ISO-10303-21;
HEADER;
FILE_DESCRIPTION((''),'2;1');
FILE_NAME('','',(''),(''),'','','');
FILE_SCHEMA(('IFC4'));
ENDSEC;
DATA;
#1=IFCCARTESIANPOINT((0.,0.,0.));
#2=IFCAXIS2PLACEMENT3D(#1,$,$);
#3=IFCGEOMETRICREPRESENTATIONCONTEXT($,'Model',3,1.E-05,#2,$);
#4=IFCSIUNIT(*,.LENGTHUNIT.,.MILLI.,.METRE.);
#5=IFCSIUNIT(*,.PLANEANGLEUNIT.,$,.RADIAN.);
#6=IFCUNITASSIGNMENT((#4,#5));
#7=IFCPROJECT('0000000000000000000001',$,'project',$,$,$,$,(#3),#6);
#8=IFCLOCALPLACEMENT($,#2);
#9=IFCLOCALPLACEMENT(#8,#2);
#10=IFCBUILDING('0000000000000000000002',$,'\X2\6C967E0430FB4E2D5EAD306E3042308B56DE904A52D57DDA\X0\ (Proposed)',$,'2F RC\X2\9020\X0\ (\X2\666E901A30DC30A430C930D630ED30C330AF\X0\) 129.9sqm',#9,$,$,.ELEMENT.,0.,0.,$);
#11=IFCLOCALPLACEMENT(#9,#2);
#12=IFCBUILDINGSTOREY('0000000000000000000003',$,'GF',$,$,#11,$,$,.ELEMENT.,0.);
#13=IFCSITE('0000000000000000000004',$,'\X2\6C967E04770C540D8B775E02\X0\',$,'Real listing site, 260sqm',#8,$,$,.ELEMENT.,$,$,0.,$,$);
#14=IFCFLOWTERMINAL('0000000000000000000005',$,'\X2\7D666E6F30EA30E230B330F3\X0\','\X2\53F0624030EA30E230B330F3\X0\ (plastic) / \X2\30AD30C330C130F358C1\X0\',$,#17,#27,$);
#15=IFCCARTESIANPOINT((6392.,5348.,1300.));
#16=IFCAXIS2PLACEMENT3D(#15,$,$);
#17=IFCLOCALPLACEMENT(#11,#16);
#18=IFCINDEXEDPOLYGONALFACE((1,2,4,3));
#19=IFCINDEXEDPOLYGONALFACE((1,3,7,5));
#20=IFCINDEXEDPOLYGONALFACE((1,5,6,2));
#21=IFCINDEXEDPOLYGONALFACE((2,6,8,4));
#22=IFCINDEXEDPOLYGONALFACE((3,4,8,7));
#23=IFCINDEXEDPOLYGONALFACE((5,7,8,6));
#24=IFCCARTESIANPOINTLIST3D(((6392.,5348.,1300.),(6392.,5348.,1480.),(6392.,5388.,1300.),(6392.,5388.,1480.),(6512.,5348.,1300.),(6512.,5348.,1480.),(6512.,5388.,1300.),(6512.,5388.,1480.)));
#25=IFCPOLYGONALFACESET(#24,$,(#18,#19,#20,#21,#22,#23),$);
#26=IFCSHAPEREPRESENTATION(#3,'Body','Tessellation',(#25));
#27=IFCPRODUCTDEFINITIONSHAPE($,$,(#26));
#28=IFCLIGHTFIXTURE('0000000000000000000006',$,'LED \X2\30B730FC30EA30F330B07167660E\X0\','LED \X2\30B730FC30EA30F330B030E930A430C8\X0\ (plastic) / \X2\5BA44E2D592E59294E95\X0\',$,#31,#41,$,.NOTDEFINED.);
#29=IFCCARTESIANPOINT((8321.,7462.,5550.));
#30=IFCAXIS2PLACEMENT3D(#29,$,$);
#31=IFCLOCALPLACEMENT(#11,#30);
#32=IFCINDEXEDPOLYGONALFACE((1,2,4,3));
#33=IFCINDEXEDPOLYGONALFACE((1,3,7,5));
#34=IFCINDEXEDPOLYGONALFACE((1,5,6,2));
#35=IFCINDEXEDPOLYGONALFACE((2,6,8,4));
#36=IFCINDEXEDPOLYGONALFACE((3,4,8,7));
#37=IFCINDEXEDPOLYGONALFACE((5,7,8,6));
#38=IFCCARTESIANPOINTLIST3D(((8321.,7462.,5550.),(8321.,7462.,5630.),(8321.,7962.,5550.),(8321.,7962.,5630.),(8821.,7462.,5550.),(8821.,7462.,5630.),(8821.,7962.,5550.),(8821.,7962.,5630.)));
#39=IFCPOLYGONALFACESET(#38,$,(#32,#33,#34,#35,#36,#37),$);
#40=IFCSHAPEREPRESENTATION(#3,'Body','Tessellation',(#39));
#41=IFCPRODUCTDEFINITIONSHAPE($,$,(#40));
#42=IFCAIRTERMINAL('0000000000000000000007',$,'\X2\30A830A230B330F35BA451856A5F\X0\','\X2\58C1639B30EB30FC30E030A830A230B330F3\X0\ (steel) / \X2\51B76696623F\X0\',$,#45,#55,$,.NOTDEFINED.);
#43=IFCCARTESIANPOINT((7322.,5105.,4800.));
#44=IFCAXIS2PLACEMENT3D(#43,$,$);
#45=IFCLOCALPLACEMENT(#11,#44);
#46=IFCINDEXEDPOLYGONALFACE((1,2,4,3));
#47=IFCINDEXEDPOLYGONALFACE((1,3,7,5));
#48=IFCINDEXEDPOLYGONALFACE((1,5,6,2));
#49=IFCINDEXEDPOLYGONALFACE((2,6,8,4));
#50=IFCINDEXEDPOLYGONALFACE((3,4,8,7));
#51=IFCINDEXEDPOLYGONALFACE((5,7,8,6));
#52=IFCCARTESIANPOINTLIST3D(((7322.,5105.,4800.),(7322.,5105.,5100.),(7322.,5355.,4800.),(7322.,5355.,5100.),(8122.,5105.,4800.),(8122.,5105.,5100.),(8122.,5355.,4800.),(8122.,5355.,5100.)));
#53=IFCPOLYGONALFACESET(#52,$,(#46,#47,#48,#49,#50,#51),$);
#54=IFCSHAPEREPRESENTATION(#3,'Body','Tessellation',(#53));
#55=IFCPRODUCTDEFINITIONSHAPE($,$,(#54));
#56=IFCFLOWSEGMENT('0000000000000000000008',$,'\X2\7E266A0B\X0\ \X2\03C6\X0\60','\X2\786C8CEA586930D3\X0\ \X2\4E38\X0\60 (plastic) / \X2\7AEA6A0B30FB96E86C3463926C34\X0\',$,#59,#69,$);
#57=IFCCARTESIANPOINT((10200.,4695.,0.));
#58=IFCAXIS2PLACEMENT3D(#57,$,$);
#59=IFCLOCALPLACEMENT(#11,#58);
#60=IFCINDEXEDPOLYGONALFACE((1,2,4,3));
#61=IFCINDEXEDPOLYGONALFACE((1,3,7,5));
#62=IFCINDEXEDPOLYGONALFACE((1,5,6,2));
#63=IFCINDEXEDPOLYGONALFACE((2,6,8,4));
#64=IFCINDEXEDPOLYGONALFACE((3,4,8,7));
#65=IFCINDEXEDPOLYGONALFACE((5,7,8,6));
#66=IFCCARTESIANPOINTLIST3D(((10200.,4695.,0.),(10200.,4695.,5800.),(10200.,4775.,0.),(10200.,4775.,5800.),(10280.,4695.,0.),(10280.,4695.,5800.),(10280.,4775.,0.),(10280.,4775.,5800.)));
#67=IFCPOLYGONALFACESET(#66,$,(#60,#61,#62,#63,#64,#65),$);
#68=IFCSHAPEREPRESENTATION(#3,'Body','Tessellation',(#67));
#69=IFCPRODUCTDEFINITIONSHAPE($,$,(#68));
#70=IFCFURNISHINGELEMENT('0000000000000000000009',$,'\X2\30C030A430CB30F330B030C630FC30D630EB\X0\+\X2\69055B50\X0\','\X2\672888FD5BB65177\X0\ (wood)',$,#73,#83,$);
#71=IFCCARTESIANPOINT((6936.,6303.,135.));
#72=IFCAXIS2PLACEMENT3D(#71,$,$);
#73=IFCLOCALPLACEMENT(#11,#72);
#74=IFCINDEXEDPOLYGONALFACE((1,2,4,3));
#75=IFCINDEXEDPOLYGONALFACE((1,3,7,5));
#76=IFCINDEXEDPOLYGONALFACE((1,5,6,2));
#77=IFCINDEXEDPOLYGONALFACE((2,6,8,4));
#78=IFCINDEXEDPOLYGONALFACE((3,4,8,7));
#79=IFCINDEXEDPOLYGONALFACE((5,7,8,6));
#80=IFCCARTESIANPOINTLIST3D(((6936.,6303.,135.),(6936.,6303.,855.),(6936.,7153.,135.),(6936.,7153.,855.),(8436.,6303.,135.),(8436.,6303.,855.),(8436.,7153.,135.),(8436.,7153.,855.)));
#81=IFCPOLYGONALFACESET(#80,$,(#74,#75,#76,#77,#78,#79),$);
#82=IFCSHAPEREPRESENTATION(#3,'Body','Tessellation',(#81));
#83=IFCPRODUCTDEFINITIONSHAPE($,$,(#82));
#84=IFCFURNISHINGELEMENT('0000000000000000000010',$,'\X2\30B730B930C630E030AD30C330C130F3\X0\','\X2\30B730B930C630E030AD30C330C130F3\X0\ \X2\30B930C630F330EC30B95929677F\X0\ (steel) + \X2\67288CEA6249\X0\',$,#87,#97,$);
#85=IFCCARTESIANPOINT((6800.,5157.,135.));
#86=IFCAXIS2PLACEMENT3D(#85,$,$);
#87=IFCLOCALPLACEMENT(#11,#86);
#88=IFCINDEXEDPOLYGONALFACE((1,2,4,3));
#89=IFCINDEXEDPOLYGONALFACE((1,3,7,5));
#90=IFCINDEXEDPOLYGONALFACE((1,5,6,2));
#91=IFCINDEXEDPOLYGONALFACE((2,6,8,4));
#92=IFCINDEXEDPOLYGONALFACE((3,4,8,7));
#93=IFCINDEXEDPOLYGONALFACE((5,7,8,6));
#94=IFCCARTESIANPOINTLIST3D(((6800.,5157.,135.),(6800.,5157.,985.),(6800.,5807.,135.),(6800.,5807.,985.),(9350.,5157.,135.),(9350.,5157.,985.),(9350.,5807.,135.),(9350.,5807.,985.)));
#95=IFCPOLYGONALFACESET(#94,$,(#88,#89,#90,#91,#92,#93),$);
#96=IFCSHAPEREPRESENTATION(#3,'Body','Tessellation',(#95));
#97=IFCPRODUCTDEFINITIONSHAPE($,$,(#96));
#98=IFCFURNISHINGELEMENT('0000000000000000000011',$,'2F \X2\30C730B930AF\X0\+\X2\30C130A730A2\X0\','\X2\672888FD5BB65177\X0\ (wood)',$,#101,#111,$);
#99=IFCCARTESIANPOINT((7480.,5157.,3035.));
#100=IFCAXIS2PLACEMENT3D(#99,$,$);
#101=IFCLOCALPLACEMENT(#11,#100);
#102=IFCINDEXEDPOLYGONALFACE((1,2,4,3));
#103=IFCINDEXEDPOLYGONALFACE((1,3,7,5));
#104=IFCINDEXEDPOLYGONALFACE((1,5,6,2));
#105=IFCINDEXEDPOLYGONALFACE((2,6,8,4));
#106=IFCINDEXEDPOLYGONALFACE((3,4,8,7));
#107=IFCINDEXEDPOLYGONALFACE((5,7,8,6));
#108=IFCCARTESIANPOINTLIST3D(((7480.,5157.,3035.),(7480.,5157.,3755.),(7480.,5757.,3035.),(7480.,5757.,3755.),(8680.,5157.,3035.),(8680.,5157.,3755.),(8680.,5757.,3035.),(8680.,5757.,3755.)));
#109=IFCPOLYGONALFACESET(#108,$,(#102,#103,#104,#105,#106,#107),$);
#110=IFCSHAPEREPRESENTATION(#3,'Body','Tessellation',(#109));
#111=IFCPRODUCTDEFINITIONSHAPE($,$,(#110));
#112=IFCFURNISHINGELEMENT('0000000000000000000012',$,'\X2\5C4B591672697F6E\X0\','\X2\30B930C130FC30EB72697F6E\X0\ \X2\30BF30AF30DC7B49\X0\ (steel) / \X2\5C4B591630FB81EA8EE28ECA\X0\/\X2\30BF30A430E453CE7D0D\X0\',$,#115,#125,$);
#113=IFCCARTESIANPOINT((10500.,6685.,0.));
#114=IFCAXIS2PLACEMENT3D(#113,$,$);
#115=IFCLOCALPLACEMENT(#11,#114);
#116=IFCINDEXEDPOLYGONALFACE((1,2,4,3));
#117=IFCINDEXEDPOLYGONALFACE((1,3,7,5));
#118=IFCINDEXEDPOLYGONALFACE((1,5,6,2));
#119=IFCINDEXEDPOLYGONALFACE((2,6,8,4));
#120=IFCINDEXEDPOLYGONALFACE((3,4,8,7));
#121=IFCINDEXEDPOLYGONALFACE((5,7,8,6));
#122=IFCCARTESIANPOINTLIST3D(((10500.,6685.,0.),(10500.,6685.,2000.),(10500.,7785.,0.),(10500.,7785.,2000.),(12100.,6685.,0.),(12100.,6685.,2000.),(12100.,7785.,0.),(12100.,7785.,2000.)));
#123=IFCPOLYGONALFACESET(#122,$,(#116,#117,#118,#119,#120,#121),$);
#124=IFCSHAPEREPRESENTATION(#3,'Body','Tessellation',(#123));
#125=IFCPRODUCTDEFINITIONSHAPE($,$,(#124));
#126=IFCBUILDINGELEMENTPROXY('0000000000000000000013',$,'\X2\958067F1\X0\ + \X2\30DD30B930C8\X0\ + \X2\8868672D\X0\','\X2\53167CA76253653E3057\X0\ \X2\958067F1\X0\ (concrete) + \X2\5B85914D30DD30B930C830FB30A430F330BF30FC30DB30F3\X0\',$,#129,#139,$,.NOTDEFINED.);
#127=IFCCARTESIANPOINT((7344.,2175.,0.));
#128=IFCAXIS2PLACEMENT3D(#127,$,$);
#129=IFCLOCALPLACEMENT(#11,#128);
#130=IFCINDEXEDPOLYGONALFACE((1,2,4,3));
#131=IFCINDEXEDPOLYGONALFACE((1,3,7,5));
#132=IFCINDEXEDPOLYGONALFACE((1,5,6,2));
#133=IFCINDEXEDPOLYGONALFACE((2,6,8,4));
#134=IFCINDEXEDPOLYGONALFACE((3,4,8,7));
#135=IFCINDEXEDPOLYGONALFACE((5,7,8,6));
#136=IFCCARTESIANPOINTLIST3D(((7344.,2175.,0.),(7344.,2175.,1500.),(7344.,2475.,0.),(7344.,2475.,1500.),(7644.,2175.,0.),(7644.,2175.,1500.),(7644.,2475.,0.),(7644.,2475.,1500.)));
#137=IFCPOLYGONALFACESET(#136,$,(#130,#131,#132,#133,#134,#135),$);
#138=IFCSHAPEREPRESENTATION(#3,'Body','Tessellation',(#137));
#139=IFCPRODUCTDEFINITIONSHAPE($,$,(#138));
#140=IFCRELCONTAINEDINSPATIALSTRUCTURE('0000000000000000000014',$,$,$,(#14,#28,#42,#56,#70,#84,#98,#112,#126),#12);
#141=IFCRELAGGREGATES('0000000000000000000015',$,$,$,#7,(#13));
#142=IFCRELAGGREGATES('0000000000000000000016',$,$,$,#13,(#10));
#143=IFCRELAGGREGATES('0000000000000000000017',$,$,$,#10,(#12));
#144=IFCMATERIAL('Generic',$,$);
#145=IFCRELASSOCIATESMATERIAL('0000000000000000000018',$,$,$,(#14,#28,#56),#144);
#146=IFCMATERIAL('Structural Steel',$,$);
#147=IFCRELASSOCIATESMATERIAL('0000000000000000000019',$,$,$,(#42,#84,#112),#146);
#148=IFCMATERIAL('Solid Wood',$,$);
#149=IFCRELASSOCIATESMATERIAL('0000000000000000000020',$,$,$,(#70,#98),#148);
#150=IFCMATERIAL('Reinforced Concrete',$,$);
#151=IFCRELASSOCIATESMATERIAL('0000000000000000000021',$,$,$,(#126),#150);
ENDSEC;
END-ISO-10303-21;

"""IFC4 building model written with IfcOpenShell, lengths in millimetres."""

from ifc_helpers import new_model, si_unit, frame, frame_2d, origin, place, context, project, spatial, rectangle, extrude, material, element, save


model = new_model("IFC4")

# Units and contexts
model_context = context("Model", 3, precision=1e-05, world=origin())
ifc_project = project(units=[si_unit("LENGTHUNIT", "METRE", prefix="MILLI"), si_unit("PLANEANGLEUNIT", "RADIAN")], contexts=[model_context])

# Site, building, storey
site_placement = place(None, origin())
site = spatial("IfcSite", under=ifc_project, at=site_placement, Name="沖縄県名護市", ObjectType="Real listing site, 260sqm", CompositionType="ELEMENT", RefElevation=0.0)
building_placement = place(site_placement, origin())
building = spatial("IfcBuilding", under=site, at=building_placement, Name="沖縄・中庭のある回遊動線 (Proposed)", ObjectType="2F RC造 (普通ボイドブロック) 129.9sqm", CompositionType="ELEMENT", ElevationOfRefHeight=0.0, ElevationOfTerrain=0.0)
storey_placement = place(building_placement, origin())
storey = spatial("IfcBuildingStorey", under=building, at=storey_placement, Name="GF", CompositionType="ELEMENT", Elevation=0.0)

# Shared definitions
ifc_material_1 = material(Name="Solid Wood")

# Shared definitions
ifc_material_2 = material(Name="Reinforced Concrete")

# Shared definitions
ifc_material_3 = material(Name="Structural Steel")

# Flow terminal
ifc_material_4 = material(Name="Generic")
flow_terminal_1_placement = place(storey_placement, frame((6392.0, 5348.0, 1300.0)))
element("IfcFlowTerminal", 1, at=flow_terminal_1_placement, inside=storey, material=ifc_material_4, Name="給湯リモコン", Description="台所リモコン (plastic) / キッチン壁", context=model_context, shape_type="SweptSolid", body=[
    extrude(rectangle(XDim=120.0, YDim=40.0, at=frame_2d((60.0, 20.0))), frame((6392.0, 5348.0, 1300.0)), (0.0, 0.0, 1.0), 180.0),
])

# Light fixture
light_fixture_placement = place(storey_placement, frame((8321.0, 7462.0, 5550.0)))
element("IfcLightFixture", 2, at=light_fixture_placement, inside=storey, material=ifc_material_4, Name="LED シーリング照明", Description="LED シーリングライト (plastic) / 室中央天井", PredefinedType="NOTDEFINED", context=model_context, shape_type="SweptSolid", body=[
    extrude(rectangle(XDim=500.0, YDim=500.0, at=frame_2d((250.0, 250.0))), frame((8321.0, 7462.0, 5550.0)), (0.0, 0.0, 1.0), 80.0),
])

# Air terminal
air_terminal_placement = place(storey_placement, frame((7322.0, 5105.0, 4800.0)))
element("IfcAirTerminal", 3, at=air_terminal_placement, inside=storey, material=ifc_material_3, Name="エアコン室内機", Description="壁掛ルームエアコン (steel) / 冷暖房", PredefinedType="NOTDEFINED", context=model_context, shape_type="SweptSolid", body=[
    extrude(rectangle(XDim=800.0, YDim=250.0, at=frame_2d((400.0, 125.0))), frame((7322.0, 5105.0, 4800.0)), (0.0, 0.0, 1.0), 300.0),
])

# Flow segment
flow_segment_placement = place(storey_placement, frame((10200.0, 4695.0, 0.0)))
element("IfcFlowSegment", 4, at=flow_segment_placement, inside=storey, material=ifc_material_4, Name="縦樋 φ60", Description="硬質塩ビ 丸60 (plastic) / 竪樋・雨水排水", context=model_context, shape_type="SweptSolid", body=[
    extrude(rectangle(XDim=80.0, YDim=80.0, at=frame_2d((40.0, 40.0))), frame((10200.0, 4695.0, 0.0)), (0.0, 0.0, 1.0), 5800.0),
])

# Furnishing elements
furnishing_1_placement = place(storey_placement, frame((6936.0, 6303.0, 135.0)))
element("IfcFurnishingElement", 5, at=furnishing_1_placement, inside=storey, material=ifc_material_1, Name="ダイニングテーブル+椅子", Description="木製家具 (wood)", context=model_context, shape_type="SweptSolid", body=[
    extrude(rectangle(XDim=1500.0, YDim=850.0, at=frame_2d((750.0, 425.0))), frame((6936.0, 6303.0, 135.0)), (0.0, 0.0, 1.0), 720.0),
])
furnishing_2_placement = place(storey_placement, frame((6800.0, 5157.0, 135.0)))
element("IfcFurnishingElement", 6, at=furnishing_2_placement, inside=storey, material=ifc_material_3, Name="システムキッチン", Description="システムキッチン ステンレス天板 (steel) + 木質扉", context=model_context, shape_type="SweptSolid", body=[
    extrude(rectangle(XDim=2550.0, YDim=650.0, at=frame_2d((1275.0, 325.0))), frame((6800.0, 5157.0, 135.0)), (0.0, 0.0, 1.0), 850.0),
])
furnishing_3_placement = place(storey_placement, frame((7480.0, 5157.0, 3035.0)))
element("IfcFurnishingElement", 7, at=furnishing_3_placement, inside=storey, material=ifc_material_1, Name="2F デスク+チェア", Description="木製家具 (wood)", context=model_context, shape_type="SweptSolid", body=[
    extrude(rectangle(XDim=1200.0, YDim=600.0, at=frame_2d((600.0, 300.0))), frame((7480.0, 5157.0, 3035.0)), (0.0, 0.0, 1.0), 720.0),
])
furnishing_4_placement = place(storey_placement, frame((10500.0, 6685.0, 0.0)))
element("IfcFurnishingElement", 8, at=furnishing_4_placement, inside=storey, material=ifc_material_3, Name="屋外物置", Description="スチール物置 タクボ等 (steel) / 屋外・自転車/タイヤ収納", context=model_context, shape_type="SweptSolid", body=[
    extrude(rectangle(XDim=1600.0, YDim=1100.0, at=frame_2d((800.0, 550.0))), frame((10500.0, 6685.0, 0.0)), (0.0, 0.0, 1.0), 2000.0),
])

# Building element proxy
proxy_placement = place(storey_placement, frame((7344.0, 2175.0, 0.0)))
element("IfcBuildingElementProxy", 9, at=proxy_placement, inside=storey, material=ifc_material_2, Name="門柱 + ポスト + 表札", Description="化粧打放し 門柱 (concrete) + 宅配ポスト・インターホン", PredefinedType="NOTDEFINED", context=model_context, shape_type="SweptSolid", body=[
    extrude(rectangle(XDim=300.0, YDim=300.0, at=frame_2d((150.0, 150.0))), frame((7344.0, 2175.0, 0.0)), (0.0, 0.0, 1.0), 1500.0),
])

save(model, "model.ifc")
